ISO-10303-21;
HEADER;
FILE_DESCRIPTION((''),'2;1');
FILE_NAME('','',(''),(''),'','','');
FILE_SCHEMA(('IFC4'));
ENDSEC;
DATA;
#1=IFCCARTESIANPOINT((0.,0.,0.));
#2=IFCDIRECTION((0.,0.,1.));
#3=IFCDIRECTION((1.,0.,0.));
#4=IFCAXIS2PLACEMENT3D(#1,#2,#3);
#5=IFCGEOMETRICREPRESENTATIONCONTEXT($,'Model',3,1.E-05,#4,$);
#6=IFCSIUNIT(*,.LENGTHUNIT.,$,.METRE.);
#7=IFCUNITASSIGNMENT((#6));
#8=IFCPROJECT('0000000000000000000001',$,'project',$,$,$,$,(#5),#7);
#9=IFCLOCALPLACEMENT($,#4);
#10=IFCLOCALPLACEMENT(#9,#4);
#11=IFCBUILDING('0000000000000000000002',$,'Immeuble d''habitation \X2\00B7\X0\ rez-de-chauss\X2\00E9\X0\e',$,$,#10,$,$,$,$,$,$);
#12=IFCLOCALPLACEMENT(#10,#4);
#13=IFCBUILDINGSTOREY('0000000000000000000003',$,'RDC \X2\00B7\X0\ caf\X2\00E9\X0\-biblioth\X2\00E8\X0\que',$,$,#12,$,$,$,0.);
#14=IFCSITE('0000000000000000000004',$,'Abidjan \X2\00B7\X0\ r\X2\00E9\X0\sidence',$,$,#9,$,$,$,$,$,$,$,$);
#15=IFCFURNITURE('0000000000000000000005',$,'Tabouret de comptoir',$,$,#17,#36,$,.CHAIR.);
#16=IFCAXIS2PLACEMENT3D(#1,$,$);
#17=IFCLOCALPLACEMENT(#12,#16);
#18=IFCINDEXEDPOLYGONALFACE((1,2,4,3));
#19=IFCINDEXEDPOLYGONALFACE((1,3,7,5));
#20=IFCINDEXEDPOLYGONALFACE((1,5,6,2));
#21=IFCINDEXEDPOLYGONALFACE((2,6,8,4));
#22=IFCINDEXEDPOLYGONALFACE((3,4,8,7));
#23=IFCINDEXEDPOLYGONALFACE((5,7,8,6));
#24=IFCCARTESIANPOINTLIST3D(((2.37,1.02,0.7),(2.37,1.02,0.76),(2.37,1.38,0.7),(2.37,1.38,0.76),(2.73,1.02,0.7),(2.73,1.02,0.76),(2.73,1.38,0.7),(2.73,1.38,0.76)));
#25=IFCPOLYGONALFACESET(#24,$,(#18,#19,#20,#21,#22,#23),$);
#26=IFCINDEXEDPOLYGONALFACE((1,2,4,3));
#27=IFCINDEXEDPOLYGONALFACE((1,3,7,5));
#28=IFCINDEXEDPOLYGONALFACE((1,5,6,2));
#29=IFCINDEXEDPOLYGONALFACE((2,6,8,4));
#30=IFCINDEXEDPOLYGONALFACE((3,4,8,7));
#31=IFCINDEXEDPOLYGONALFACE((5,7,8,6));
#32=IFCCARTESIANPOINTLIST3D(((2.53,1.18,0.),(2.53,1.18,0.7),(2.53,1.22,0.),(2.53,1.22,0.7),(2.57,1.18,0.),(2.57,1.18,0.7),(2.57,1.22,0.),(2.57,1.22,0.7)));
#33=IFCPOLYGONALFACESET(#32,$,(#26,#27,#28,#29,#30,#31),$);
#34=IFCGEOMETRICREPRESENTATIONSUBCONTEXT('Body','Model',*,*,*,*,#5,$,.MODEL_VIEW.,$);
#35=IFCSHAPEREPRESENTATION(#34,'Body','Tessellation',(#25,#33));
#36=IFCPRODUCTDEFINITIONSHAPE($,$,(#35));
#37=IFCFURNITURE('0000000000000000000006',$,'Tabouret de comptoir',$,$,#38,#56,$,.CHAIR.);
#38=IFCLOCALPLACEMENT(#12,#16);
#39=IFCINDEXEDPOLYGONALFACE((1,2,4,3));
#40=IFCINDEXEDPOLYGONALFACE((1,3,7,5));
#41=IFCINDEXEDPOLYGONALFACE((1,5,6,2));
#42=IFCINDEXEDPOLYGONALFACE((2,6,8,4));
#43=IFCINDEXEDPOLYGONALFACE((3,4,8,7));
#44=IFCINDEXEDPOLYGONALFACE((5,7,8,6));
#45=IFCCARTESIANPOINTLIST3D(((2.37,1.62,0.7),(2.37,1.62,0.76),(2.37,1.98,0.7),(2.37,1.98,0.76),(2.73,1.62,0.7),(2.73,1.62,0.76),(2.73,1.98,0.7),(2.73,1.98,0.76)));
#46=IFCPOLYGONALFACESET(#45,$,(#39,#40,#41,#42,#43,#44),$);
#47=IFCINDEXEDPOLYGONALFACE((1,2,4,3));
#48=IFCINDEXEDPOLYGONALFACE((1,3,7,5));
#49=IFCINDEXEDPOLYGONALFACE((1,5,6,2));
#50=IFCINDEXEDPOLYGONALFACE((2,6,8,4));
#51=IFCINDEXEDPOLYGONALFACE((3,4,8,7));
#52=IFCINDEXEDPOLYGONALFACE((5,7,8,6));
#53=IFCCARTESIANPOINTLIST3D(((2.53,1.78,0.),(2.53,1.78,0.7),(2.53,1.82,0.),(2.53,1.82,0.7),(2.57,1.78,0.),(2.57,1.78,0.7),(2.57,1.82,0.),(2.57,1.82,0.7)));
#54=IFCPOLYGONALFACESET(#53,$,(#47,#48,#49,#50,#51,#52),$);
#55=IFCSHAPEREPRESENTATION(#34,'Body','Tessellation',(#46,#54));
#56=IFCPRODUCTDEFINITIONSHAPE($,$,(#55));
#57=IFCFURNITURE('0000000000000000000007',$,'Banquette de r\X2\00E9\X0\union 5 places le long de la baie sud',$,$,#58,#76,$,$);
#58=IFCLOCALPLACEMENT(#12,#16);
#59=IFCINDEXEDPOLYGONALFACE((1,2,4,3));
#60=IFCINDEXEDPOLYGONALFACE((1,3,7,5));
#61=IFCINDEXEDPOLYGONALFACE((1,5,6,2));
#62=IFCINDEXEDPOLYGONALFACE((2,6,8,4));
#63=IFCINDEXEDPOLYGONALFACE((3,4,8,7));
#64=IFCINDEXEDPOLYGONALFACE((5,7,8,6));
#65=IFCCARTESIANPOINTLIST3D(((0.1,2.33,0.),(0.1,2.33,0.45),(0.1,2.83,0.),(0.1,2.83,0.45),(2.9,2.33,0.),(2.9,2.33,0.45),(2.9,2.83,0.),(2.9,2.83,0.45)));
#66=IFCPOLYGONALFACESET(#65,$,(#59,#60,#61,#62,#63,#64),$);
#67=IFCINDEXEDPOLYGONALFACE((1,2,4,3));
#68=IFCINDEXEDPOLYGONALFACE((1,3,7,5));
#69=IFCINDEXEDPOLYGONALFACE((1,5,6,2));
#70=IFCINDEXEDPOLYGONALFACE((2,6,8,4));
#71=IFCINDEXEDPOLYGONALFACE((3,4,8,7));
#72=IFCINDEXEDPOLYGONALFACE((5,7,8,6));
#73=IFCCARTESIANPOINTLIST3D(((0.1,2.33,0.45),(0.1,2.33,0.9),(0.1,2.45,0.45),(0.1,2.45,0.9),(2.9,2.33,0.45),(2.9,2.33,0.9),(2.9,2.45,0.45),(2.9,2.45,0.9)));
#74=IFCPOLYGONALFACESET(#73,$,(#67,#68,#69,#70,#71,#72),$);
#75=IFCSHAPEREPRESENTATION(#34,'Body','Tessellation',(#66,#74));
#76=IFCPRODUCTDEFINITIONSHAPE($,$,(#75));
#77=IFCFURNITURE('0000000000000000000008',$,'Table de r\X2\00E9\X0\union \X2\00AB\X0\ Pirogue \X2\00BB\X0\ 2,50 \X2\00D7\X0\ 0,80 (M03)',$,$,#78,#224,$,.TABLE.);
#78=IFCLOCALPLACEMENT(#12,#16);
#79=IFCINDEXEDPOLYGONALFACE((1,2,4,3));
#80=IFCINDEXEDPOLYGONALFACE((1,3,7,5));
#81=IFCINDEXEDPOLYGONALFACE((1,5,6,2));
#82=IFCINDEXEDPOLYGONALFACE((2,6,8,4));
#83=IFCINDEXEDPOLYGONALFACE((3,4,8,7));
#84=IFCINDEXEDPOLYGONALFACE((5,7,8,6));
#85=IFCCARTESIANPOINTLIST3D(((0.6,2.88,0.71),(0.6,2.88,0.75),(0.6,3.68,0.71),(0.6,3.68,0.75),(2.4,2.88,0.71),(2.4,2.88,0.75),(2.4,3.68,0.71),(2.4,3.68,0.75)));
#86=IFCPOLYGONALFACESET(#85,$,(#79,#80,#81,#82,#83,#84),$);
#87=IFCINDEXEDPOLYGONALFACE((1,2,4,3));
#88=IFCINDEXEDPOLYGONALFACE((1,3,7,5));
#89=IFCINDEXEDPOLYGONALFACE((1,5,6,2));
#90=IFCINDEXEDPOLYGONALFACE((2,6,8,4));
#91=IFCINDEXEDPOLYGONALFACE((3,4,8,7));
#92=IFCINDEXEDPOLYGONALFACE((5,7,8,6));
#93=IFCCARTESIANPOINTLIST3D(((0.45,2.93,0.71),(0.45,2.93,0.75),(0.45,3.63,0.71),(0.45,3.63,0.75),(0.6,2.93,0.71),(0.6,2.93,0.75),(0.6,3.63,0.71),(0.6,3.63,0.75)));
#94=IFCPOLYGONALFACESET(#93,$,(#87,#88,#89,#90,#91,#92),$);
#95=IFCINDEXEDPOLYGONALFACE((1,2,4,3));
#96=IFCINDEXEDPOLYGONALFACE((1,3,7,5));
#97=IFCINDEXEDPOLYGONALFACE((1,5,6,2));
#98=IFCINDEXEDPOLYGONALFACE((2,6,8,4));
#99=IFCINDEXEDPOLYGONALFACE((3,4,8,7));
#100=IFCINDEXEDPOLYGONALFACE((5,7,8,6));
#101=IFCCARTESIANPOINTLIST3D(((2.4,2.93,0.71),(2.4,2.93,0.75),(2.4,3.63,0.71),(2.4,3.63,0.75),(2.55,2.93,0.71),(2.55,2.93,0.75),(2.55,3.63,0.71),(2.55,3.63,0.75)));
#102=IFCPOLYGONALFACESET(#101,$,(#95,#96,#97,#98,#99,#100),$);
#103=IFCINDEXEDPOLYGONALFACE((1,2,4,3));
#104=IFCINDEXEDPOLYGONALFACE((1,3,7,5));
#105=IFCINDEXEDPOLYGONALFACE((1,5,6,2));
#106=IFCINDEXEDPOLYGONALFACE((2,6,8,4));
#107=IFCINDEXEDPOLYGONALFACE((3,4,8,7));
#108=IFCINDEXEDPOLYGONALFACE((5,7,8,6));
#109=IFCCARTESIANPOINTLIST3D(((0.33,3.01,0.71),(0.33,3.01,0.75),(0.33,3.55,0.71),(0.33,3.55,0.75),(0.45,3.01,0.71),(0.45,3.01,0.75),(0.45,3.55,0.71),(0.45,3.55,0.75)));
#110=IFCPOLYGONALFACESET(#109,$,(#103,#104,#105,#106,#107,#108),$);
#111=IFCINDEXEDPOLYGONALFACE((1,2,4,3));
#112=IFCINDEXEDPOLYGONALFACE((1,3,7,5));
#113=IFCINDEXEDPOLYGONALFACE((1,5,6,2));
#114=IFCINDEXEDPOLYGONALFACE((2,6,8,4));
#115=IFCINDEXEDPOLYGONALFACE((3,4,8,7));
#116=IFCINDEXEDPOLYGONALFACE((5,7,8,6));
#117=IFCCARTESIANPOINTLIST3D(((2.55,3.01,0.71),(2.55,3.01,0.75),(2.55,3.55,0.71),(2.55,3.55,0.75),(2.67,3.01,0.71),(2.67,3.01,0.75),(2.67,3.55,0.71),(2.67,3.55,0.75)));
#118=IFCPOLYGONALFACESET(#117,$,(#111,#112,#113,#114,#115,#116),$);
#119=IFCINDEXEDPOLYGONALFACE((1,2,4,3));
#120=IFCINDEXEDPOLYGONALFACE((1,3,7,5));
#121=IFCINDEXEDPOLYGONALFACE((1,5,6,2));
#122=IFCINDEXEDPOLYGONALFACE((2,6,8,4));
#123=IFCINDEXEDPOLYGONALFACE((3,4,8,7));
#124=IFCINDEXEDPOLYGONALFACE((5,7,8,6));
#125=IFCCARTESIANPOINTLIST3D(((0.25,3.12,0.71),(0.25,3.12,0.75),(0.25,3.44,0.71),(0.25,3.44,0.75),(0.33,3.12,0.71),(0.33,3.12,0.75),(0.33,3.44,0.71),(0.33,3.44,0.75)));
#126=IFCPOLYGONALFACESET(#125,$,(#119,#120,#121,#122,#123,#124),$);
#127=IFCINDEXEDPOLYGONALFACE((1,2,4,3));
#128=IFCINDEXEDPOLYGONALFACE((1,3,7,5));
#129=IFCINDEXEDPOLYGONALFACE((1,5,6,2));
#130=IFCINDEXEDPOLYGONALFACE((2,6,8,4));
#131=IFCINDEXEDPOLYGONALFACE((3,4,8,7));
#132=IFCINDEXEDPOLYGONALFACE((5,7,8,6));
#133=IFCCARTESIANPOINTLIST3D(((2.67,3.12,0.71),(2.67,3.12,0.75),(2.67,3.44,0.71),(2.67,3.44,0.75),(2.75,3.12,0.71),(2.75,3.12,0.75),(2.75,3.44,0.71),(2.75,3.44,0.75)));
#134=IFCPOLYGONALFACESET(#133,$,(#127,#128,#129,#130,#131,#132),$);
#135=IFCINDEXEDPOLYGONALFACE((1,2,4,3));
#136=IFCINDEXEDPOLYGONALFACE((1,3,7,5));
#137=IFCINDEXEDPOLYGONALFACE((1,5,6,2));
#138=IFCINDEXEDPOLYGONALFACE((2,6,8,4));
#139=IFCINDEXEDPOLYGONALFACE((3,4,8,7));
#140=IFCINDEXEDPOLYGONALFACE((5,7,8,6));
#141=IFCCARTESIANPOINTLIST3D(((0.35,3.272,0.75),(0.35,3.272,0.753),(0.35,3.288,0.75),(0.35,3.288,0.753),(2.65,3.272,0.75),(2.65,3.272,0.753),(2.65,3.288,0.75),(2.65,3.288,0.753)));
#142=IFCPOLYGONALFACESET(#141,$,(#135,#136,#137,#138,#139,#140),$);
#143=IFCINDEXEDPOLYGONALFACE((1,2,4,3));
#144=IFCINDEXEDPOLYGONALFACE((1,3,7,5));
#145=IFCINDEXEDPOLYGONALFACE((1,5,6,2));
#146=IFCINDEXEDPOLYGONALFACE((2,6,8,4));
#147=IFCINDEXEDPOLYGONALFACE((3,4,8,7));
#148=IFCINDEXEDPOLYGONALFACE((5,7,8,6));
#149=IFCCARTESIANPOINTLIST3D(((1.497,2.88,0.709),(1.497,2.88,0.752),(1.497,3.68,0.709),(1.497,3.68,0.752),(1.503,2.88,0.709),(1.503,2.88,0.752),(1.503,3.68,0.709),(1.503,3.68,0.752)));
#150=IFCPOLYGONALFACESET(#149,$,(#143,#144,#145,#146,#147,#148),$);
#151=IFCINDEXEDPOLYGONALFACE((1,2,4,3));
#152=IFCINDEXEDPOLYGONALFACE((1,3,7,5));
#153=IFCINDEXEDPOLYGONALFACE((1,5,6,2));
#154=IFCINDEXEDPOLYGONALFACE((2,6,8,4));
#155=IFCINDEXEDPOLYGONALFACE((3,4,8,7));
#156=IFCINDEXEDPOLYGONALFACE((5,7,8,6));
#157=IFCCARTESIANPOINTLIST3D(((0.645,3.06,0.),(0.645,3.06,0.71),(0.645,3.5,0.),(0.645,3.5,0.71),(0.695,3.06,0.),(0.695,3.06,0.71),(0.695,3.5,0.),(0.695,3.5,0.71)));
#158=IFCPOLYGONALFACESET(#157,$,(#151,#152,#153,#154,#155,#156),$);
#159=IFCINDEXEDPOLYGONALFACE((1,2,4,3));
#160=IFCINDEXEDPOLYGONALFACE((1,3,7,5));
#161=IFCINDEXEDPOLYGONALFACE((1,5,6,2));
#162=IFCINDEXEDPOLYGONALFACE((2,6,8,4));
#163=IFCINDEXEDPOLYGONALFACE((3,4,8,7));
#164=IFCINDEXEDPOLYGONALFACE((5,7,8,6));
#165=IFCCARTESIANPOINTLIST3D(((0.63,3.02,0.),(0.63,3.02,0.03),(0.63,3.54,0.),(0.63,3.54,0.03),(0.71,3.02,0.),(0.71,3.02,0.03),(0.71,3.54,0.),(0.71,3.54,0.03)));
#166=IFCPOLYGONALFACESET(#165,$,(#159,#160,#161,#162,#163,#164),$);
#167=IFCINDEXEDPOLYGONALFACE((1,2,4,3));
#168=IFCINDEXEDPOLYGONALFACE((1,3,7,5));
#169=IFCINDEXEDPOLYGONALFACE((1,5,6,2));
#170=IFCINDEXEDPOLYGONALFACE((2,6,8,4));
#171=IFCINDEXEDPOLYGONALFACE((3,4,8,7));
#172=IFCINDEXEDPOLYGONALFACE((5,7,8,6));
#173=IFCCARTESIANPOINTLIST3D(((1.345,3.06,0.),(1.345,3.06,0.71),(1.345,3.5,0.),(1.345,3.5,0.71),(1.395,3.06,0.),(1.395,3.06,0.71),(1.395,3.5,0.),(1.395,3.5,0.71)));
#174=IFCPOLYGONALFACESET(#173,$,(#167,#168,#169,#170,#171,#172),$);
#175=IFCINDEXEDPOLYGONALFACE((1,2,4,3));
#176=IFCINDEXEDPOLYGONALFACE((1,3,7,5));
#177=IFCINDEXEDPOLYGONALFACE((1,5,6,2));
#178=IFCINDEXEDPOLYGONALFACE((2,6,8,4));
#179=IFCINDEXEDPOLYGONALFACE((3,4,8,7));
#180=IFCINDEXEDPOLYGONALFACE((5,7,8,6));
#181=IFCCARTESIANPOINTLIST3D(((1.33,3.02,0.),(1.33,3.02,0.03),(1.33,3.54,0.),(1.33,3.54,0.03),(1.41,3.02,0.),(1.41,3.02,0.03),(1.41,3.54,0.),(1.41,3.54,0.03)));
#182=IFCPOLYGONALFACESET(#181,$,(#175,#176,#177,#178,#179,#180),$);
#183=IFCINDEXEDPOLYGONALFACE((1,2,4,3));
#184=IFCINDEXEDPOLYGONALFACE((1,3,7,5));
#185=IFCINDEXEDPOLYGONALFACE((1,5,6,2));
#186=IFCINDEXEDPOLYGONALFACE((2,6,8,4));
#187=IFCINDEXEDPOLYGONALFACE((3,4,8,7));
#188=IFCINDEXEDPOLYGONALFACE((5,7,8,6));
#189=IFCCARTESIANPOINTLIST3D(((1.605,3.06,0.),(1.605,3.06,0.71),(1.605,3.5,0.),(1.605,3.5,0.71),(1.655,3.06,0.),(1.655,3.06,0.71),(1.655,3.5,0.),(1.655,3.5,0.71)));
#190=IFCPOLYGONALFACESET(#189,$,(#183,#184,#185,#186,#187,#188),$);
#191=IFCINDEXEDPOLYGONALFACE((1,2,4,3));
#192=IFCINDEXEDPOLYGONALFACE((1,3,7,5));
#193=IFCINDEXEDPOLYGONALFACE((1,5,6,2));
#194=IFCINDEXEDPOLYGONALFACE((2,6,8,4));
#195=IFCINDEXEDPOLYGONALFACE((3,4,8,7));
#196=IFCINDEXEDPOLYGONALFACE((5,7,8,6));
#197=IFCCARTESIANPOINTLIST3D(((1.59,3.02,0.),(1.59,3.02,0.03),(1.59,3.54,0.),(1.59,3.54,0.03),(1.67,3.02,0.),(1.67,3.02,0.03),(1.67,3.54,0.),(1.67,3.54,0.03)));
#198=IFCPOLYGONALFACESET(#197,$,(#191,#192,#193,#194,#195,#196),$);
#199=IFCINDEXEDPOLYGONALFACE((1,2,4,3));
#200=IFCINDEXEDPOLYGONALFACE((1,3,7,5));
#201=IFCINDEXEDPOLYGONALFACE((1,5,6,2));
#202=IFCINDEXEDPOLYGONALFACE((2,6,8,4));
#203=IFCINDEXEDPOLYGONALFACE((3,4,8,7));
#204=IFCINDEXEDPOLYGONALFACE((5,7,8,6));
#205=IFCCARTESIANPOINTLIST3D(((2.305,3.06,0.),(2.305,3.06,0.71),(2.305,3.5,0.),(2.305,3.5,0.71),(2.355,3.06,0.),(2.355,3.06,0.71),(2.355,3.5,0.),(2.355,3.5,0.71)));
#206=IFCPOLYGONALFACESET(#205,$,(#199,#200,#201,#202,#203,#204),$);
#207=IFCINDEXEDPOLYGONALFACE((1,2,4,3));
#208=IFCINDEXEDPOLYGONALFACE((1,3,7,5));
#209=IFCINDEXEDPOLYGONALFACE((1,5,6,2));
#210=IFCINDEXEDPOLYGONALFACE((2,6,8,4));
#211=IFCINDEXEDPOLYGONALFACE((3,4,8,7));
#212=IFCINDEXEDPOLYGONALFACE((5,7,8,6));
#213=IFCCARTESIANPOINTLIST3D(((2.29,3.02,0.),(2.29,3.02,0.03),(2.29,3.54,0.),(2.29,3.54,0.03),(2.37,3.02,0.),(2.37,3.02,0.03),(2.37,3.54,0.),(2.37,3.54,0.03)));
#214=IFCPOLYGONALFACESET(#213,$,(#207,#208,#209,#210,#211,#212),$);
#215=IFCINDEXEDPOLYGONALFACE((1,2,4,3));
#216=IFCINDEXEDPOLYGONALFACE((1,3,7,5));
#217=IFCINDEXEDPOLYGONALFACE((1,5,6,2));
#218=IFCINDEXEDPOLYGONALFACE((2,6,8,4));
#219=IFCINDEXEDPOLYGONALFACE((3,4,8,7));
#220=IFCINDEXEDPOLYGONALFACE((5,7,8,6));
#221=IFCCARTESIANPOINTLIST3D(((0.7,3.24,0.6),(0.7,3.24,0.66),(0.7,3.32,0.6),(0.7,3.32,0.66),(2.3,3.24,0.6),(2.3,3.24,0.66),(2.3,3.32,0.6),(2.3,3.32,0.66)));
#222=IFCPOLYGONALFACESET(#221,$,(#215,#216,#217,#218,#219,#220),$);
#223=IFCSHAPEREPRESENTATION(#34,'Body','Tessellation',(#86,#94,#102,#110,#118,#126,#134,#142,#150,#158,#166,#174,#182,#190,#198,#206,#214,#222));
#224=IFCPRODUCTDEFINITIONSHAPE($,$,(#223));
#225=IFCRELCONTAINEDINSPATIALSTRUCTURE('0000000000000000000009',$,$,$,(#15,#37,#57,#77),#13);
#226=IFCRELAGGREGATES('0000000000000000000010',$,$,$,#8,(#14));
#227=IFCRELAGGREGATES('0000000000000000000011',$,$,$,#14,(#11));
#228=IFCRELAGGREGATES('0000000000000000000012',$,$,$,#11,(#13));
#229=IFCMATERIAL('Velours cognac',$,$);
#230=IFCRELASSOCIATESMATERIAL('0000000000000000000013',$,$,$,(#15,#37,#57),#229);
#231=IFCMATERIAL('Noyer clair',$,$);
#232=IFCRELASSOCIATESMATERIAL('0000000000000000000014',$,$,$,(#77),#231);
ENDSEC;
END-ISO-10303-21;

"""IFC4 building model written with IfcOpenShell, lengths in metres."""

from ifc_helpers import new_model, si_unit, frame, frame_2d, origin, origin_with_axes, place, context, subcontext, project, spatial, rectangle, extrude, material, element, save


model = new_model("IFC4")

# Units and contexts
model_context = context("Model", 3, precision=1e-05, world=origin_with_axes())
body_context = subcontext(model_context, "Body", "Model", "MODEL_VIEW")
ifc_project = project(units=[si_unit("LENGTHUNIT", "METRE")], contexts=[model_context])

# Site, building, storey
site_placement = place(None, origin_with_axes())
site = spatial("IfcSite", under=ifc_project, at=site_placement, Name="Abidjan · résidence")
building_placement = place(site_placement, origin_with_axes())
building = spatial("IfcBuilding", under=site, at=building_placement, Name="Immeuble d'habitation · rez-de-chaussée")
storey_placement = place(building_placement, origin_with_axes())
storey = spatial("IfcBuildingStorey", under=building, at=storey_placement, Name="RDC · café-bibliothèque", Elevation=0.0)

# Furniture
ifc_material_1 = material(Name="Velours cognac")
furniture_1_placement = place(storey_placement, origin_with_axes())
element("IfcFurniture", 1, at=furniture_1_placement, inside=storey, material=ifc_material_1, Name="Tabouret de comptoir", PredefinedType="CHAIR", context=body_context, shape_type="SweptSolid", body=[
    extrude(rectangle(XDim=0.36, YDim=0.36, at=frame_2d((2.55, 1.2))), frame((0.0, 0.0, 0.7)), (0.0, 0.0, 1.0), 0.06),
    extrude(rectangle(XDim=0.04, YDim=0.04, at=frame_2d((2.55, 1.2))), origin(), (0.0, 0.0, 1.0), 0.7),
])
furniture_2_placement = place(storey_placement, origin_with_axes())
element("IfcFurniture", 2, at=furniture_2_placement, inside=storey, material=ifc_material_1, Name="Tabouret de comptoir", PredefinedType="CHAIR", context=body_context, shape_type="SweptSolid", body=[
    extrude(rectangle(XDim=0.36, YDim=0.36, at=frame_2d((2.55, 1.8))), frame((0.0, 0.0, 0.7)), (0.0, 0.0, 1.0), 0.06),
    extrude(rectangle(XDim=0.04, YDim=0.04, at=frame_2d((2.55, 1.8))), origin(), (0.0, 0.0, 1.0), 0.7),
])
furniture_3_placement = place(storey_placement, origin_with_axes())
element("IfcFurniture", 3, at=furniture_3_placement, inside=storey, material=ifc_material_1, Name="Banquette de réunion 5 places le long de la baie sud", context=body_context, shape_type="SweptSolid", body=[
    extrude(rectangle(XDim=2.8, YDim=0.5, at=frame_2d((1.5, 2.58))), origin(), (0.0, 0.0, 1.0), 0.45),
    extrude(rectangle(XDim=2.8, YDim=0.12, at=frame_2d((1.5, 2.39))), frame((0.0, 0.0, 0.45)), (0.0, 0.0, 1.0), 0.45),
])
ifc_material_2 = material(Name="Noyer clair")
furniture_4_placement = place(storey_placement, origin_with_axes())
element("IfcFurniture", 4, at=furniture_4_placement, inside=storey, material=ifc_material_2, Name="Table de réunion « Pirogue » 2,50 × 0,80 (M03)", PredefinedType="TABLE", context=body_context, shape_type="SweptSolid", body=[
    extrude(rectangle(XDim=1.8, YDim=0.8, at=frame_2d((1.5, 3.28))), frame((0.0, 0.0, 0.71)), (0.0, 0.0, 1.0), 0.04),
    extrude(rectangle(XDim=0.15, YDim=0.7, at=frame_2d((0.525, 3.28))), frame((0.0, 0.0, 0.71)), (0.0, 0.0, 1.0), 0.04),
    extrude(rectangle(XDim=0.15, YDim=0.7, at=frame_2d((2.475, 3.28))), frame((0.0, 0.0, 0.71)), (0.0, 0.0, 1.0), 0.04),
    extrude(rectangle(XDim=0.12, YDim=0.54, at=frame_2d((0.39, 3.28))), frame((0.0, 0.0, 0.71)), (0.0, 0.0, 1.0), 0.04),
    extrude(rectangle(XDim=0.12, YDim=0.54, at=frame_2d((2.61, 3.28))), frame((0.0, 0.0, 0.71)), (0.0, 0.0, 1.0), 0.04),
    extrude(rectangle(XDim=0.08, YDim=0.32, at=frame_2d((0.29, 3.28))), frame((0.0, 0.0, 0.71)), (0.0, 0.0, 1.0), 0.04),
    extrude(rectangle(XDim=0.08, YDim=0.32, at=frame_2d((2.71, 3.28))), frame((0.0, 0.0, 0.71)), (0.0, 0.0, 1.0), 0.04),
    extrude(rectangle(XDim=2.3, YDim=0.016, at=frame_2d((1.5, 3.28))), frame((0.0, 0.0, 0.75)), (0.0, 0.0, 1.0), 0.003),
    extrude(rectangle(XDim=0.006, YDim=0.8, at=frame_2d((1.5, 3.28))), frame((0.0, 0.0, 0.709)), (0.0, 0.0, 1.0), 0.043),
    extrude(rectangle(XDim=0.05, YDim=0.44, at=frame_2d((0.67, 3.28))), origin(), (0.0, 0.0, 1.0), 0.71),
    extrude(rectangle(XDim=0.08, YDim=0.52, at=frame_2d((0.67, 3.28))), origin(), (0.0, 0.0, 1.0), 0.03),
    extrude(rectangle(XDim=0.05, YDim=0.44, at=frame_2d((1.37, 3.28))), origin(), (0.0, 0.0, 1.0), 0.71),
    extrude(rectangle(XDim=0.08, YDim=0.52, at=frame_2d((1.37, 3.28))), origin(), (0.0, 0.0, 1.0), 0.03),
    extrude(rectangle(XDim=0.05, YDim=0.44, at=frame_2d((1.63, 3.28))), origin(), (0.0, 0.0, 1.0), 0.71),
    extrude(rectangle(XDim=0.08, YDim=0.52, at=frame_2d((1.63, 3.28))), origin(), (0.0, 0.0, 1.0), 0.03),
    extrude(rectangle(XDim=0.05, YDim=0.44, at=frame_2d((2.33, 3.28))), origin(), (0.0, 0.0, 1.0), 0.71),
    extrude(rectangle(XDim=0.08, YDim=0.52, at=frame_2d((2.33, 3.28))), origin(), (0.0, 0.0, 1.0), 0.03),
    extrude(rectangle(XDim=1.6, YDim=0.08, at=frame_2d((1.5, 3.28))), frame((0.0, 0.0, 0.6)), (0.0, 0.0, 1.0), 0.06),
])

save(model, "model.ifc")
